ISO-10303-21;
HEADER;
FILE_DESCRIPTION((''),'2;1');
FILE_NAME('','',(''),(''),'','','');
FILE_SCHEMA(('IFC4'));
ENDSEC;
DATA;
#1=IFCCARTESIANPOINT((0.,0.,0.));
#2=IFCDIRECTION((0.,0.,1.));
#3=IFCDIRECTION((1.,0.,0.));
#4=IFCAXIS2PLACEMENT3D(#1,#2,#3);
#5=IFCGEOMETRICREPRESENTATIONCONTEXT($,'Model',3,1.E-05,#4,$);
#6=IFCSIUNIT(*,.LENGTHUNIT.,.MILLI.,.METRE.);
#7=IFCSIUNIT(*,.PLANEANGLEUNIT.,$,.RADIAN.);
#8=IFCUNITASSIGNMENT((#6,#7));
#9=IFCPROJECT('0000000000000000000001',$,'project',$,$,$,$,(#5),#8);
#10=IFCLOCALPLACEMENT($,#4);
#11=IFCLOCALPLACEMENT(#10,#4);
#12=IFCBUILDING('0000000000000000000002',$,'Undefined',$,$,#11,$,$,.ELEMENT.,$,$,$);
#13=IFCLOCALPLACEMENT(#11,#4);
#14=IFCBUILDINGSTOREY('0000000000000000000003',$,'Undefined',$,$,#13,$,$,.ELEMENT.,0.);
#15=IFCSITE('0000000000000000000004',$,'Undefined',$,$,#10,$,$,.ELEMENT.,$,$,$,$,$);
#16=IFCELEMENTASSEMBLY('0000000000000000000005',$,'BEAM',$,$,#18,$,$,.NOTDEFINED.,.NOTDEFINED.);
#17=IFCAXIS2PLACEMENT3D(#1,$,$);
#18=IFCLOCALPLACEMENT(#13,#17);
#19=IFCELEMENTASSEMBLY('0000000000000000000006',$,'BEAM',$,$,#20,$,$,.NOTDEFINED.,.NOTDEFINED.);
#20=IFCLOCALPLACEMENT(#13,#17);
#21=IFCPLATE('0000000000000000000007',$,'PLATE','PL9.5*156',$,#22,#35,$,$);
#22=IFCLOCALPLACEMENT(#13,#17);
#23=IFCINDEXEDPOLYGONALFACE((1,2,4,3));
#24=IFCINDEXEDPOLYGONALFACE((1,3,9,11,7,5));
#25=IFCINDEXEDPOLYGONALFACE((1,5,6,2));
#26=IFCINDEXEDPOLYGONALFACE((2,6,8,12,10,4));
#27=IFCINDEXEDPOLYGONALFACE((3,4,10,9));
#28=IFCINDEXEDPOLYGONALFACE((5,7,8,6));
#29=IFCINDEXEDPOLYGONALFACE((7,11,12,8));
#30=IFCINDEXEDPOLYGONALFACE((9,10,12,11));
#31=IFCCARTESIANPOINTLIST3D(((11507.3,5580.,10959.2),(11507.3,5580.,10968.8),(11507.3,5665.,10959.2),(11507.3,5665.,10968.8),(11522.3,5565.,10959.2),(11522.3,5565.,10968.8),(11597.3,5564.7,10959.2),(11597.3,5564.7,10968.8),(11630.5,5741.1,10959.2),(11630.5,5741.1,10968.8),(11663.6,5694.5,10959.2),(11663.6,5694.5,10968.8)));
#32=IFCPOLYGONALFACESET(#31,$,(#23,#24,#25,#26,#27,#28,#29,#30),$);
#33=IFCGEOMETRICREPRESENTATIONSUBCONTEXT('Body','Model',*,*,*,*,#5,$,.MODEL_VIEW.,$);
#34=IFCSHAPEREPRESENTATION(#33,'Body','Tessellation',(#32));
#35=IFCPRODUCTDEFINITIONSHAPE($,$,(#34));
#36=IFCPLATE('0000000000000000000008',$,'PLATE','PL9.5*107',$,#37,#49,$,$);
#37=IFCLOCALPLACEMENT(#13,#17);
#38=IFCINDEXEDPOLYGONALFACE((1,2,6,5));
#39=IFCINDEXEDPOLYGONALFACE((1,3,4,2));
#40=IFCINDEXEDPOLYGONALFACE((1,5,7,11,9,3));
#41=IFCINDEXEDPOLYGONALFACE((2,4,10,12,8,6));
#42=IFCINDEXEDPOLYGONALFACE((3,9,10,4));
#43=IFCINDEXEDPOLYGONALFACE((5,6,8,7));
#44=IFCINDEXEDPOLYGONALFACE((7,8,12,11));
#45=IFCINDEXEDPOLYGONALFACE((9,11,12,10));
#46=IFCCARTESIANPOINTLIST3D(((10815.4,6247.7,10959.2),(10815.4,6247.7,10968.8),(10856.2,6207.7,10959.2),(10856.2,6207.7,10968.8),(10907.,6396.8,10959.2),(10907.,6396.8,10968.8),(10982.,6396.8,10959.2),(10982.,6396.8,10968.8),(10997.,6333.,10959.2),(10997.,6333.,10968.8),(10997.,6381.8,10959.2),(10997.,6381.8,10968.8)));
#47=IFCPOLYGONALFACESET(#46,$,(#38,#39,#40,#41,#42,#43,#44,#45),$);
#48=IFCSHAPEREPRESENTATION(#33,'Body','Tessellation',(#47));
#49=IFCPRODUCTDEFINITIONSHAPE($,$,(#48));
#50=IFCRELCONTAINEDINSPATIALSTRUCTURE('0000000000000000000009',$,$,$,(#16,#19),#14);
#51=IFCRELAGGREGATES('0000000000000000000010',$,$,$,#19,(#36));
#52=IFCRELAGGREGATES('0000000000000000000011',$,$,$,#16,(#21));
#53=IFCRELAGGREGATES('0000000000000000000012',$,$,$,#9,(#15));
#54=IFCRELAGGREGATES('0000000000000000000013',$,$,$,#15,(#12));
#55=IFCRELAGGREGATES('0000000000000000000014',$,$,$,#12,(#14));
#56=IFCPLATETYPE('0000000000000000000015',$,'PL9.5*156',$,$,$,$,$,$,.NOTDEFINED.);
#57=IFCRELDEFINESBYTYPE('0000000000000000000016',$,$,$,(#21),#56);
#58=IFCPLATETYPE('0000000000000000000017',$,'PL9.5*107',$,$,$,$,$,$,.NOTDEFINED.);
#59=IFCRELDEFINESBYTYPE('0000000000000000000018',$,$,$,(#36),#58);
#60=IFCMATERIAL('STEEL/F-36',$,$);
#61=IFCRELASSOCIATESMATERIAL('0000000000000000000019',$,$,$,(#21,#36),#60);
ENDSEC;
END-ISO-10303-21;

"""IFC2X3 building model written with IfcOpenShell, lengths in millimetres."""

from ifc_helpers import new_model, si_unit, frame, origin_with_axes, place, context, subcontext, project, spatial, polyline, outline, extrude, material, type_object, element, aggregate, save


model = new_model("IFC2X3")

# Units and contexts
model_context = context("Model", 3, precision=1e-05, world=origin_with_axes())
body_context = subcontext(model_context, "Body", "Model", "MODEL_VIEW")
ifc_project = project(units=[si_unit("LENGTHUNIT", "METRE", prefix="MILLI"), si_unit("PLANEANGLEUNIT", "RADIAN")], contexts=[model_context])

# Site, building, storey
site_placement = place(None, origin_with_axes())
site = spatial("IfcSite", under=ifc_project, at=site_placement, Name="Undefined", CompositionType="ELEMENT")
building_placement = place(site_placement, origin_with_axes())
building = spatial("IfcBuilding", under=site, at=building_placement, Name="Undefined", CompositionType="ELEMENT")
storey_placement = place(building_placement, origin_with_axes())
storey = spatial("IfcBuildingStorey", under=building, at=storey_placement, Name="Undefined", CompositionType="ELEMENT", Elevation=0.0)

# Element assembly
ifc_material_1 = material(Name="STEEL/F-36")
assembly_1_placement = place(storey_placement, origin_with_axes())
assembly_1 = element("IfcElementAssembly", 1, at=assembly_1_placement, inside=storey, Name="BEAM", AssemblyPlace="NOTDEFINED", PredefinedType="NOTDEFINED")

# Element assembly
assembly_2_placement = place(storey_placement, origin_with_axes())
assembly_2 = element("IfcElementAssembly", 2, at=assembly_2_placement, inside=storey, Name="BEAM", AssemblyPlace="NOTDEFINED", PredefinedType="NOTDEFINED")

# Plates
plate_type_1 = type_object("IfcPlateType", Name="PL9.5*156", PredefinedType="NOTDEFINED")
plate_1_placement = place(assembly_1_placement, frame((11507.3, 5665.0, 10964.0), z_axis=(0.0, 0.0, 1.0), x_axis=(-0.000002, -1.0, 0.0)))
plate_1 = element("IfcPlate", 3, at=plate_1_placement, type_object=plate_type_1, material=ifc_material_1, Name="PLATE", Description="PL9.5*156", context=body_context, shape_type="SweptSolid", body=[
    extrude(outline(polyline([(0.0, 0.0), (85.0, 0.0), (100.1, 15.0), (100.4, 90.0), (-29.4, 156.2), (-76.0, 123.2), (0.0, 0.0)])), frame((0.0, 0.0, -4.8), z_axis=(0.0, 0.0, 1.0), x_axis=(1.0, 0.0, 0.0)), (0.0, 0.0, 1.0), 9.5),
])
plate_type_2 = type_object("IfcPlateType", Name="PL9.5*107", PredefinedType="NOTDEFINED")
plate_2_placement = place(assembly_2_placement, frame((10907.0, 6396.8, 10964.0), z_axis=(0.0, 0.0, -1.0), x_axis=(1.0, 0.0, 0.0)))
plate_2 = element("IfcPlate", 4, at=plate_2_placement, type_object=plate_type_2, material=ifc_material_1, Name="PLATE", Description="PL9.5*107", context=body_context, shape_type="SweptSolid", body=[
    extrude(outline(polyline([(0.0, 0.0), (75.0, 0.0), (90.0, 15.0), (90.0, 63.8), (-50.8, 189.1), (-91.6, 149.1), (0.0, 0.0)])), frame((0.0, 0.0, -4.8), z_axis=(0.0, 0.0, 1.0), x_axis=(1.0, 0.0, 0.0)), (0.0, 0.0, 1.0), 9.5),
])
aggregate(assembly_2, [plate_2])

aggregate(assembly_1, [plate_1])

save(model, "model.ifc")
